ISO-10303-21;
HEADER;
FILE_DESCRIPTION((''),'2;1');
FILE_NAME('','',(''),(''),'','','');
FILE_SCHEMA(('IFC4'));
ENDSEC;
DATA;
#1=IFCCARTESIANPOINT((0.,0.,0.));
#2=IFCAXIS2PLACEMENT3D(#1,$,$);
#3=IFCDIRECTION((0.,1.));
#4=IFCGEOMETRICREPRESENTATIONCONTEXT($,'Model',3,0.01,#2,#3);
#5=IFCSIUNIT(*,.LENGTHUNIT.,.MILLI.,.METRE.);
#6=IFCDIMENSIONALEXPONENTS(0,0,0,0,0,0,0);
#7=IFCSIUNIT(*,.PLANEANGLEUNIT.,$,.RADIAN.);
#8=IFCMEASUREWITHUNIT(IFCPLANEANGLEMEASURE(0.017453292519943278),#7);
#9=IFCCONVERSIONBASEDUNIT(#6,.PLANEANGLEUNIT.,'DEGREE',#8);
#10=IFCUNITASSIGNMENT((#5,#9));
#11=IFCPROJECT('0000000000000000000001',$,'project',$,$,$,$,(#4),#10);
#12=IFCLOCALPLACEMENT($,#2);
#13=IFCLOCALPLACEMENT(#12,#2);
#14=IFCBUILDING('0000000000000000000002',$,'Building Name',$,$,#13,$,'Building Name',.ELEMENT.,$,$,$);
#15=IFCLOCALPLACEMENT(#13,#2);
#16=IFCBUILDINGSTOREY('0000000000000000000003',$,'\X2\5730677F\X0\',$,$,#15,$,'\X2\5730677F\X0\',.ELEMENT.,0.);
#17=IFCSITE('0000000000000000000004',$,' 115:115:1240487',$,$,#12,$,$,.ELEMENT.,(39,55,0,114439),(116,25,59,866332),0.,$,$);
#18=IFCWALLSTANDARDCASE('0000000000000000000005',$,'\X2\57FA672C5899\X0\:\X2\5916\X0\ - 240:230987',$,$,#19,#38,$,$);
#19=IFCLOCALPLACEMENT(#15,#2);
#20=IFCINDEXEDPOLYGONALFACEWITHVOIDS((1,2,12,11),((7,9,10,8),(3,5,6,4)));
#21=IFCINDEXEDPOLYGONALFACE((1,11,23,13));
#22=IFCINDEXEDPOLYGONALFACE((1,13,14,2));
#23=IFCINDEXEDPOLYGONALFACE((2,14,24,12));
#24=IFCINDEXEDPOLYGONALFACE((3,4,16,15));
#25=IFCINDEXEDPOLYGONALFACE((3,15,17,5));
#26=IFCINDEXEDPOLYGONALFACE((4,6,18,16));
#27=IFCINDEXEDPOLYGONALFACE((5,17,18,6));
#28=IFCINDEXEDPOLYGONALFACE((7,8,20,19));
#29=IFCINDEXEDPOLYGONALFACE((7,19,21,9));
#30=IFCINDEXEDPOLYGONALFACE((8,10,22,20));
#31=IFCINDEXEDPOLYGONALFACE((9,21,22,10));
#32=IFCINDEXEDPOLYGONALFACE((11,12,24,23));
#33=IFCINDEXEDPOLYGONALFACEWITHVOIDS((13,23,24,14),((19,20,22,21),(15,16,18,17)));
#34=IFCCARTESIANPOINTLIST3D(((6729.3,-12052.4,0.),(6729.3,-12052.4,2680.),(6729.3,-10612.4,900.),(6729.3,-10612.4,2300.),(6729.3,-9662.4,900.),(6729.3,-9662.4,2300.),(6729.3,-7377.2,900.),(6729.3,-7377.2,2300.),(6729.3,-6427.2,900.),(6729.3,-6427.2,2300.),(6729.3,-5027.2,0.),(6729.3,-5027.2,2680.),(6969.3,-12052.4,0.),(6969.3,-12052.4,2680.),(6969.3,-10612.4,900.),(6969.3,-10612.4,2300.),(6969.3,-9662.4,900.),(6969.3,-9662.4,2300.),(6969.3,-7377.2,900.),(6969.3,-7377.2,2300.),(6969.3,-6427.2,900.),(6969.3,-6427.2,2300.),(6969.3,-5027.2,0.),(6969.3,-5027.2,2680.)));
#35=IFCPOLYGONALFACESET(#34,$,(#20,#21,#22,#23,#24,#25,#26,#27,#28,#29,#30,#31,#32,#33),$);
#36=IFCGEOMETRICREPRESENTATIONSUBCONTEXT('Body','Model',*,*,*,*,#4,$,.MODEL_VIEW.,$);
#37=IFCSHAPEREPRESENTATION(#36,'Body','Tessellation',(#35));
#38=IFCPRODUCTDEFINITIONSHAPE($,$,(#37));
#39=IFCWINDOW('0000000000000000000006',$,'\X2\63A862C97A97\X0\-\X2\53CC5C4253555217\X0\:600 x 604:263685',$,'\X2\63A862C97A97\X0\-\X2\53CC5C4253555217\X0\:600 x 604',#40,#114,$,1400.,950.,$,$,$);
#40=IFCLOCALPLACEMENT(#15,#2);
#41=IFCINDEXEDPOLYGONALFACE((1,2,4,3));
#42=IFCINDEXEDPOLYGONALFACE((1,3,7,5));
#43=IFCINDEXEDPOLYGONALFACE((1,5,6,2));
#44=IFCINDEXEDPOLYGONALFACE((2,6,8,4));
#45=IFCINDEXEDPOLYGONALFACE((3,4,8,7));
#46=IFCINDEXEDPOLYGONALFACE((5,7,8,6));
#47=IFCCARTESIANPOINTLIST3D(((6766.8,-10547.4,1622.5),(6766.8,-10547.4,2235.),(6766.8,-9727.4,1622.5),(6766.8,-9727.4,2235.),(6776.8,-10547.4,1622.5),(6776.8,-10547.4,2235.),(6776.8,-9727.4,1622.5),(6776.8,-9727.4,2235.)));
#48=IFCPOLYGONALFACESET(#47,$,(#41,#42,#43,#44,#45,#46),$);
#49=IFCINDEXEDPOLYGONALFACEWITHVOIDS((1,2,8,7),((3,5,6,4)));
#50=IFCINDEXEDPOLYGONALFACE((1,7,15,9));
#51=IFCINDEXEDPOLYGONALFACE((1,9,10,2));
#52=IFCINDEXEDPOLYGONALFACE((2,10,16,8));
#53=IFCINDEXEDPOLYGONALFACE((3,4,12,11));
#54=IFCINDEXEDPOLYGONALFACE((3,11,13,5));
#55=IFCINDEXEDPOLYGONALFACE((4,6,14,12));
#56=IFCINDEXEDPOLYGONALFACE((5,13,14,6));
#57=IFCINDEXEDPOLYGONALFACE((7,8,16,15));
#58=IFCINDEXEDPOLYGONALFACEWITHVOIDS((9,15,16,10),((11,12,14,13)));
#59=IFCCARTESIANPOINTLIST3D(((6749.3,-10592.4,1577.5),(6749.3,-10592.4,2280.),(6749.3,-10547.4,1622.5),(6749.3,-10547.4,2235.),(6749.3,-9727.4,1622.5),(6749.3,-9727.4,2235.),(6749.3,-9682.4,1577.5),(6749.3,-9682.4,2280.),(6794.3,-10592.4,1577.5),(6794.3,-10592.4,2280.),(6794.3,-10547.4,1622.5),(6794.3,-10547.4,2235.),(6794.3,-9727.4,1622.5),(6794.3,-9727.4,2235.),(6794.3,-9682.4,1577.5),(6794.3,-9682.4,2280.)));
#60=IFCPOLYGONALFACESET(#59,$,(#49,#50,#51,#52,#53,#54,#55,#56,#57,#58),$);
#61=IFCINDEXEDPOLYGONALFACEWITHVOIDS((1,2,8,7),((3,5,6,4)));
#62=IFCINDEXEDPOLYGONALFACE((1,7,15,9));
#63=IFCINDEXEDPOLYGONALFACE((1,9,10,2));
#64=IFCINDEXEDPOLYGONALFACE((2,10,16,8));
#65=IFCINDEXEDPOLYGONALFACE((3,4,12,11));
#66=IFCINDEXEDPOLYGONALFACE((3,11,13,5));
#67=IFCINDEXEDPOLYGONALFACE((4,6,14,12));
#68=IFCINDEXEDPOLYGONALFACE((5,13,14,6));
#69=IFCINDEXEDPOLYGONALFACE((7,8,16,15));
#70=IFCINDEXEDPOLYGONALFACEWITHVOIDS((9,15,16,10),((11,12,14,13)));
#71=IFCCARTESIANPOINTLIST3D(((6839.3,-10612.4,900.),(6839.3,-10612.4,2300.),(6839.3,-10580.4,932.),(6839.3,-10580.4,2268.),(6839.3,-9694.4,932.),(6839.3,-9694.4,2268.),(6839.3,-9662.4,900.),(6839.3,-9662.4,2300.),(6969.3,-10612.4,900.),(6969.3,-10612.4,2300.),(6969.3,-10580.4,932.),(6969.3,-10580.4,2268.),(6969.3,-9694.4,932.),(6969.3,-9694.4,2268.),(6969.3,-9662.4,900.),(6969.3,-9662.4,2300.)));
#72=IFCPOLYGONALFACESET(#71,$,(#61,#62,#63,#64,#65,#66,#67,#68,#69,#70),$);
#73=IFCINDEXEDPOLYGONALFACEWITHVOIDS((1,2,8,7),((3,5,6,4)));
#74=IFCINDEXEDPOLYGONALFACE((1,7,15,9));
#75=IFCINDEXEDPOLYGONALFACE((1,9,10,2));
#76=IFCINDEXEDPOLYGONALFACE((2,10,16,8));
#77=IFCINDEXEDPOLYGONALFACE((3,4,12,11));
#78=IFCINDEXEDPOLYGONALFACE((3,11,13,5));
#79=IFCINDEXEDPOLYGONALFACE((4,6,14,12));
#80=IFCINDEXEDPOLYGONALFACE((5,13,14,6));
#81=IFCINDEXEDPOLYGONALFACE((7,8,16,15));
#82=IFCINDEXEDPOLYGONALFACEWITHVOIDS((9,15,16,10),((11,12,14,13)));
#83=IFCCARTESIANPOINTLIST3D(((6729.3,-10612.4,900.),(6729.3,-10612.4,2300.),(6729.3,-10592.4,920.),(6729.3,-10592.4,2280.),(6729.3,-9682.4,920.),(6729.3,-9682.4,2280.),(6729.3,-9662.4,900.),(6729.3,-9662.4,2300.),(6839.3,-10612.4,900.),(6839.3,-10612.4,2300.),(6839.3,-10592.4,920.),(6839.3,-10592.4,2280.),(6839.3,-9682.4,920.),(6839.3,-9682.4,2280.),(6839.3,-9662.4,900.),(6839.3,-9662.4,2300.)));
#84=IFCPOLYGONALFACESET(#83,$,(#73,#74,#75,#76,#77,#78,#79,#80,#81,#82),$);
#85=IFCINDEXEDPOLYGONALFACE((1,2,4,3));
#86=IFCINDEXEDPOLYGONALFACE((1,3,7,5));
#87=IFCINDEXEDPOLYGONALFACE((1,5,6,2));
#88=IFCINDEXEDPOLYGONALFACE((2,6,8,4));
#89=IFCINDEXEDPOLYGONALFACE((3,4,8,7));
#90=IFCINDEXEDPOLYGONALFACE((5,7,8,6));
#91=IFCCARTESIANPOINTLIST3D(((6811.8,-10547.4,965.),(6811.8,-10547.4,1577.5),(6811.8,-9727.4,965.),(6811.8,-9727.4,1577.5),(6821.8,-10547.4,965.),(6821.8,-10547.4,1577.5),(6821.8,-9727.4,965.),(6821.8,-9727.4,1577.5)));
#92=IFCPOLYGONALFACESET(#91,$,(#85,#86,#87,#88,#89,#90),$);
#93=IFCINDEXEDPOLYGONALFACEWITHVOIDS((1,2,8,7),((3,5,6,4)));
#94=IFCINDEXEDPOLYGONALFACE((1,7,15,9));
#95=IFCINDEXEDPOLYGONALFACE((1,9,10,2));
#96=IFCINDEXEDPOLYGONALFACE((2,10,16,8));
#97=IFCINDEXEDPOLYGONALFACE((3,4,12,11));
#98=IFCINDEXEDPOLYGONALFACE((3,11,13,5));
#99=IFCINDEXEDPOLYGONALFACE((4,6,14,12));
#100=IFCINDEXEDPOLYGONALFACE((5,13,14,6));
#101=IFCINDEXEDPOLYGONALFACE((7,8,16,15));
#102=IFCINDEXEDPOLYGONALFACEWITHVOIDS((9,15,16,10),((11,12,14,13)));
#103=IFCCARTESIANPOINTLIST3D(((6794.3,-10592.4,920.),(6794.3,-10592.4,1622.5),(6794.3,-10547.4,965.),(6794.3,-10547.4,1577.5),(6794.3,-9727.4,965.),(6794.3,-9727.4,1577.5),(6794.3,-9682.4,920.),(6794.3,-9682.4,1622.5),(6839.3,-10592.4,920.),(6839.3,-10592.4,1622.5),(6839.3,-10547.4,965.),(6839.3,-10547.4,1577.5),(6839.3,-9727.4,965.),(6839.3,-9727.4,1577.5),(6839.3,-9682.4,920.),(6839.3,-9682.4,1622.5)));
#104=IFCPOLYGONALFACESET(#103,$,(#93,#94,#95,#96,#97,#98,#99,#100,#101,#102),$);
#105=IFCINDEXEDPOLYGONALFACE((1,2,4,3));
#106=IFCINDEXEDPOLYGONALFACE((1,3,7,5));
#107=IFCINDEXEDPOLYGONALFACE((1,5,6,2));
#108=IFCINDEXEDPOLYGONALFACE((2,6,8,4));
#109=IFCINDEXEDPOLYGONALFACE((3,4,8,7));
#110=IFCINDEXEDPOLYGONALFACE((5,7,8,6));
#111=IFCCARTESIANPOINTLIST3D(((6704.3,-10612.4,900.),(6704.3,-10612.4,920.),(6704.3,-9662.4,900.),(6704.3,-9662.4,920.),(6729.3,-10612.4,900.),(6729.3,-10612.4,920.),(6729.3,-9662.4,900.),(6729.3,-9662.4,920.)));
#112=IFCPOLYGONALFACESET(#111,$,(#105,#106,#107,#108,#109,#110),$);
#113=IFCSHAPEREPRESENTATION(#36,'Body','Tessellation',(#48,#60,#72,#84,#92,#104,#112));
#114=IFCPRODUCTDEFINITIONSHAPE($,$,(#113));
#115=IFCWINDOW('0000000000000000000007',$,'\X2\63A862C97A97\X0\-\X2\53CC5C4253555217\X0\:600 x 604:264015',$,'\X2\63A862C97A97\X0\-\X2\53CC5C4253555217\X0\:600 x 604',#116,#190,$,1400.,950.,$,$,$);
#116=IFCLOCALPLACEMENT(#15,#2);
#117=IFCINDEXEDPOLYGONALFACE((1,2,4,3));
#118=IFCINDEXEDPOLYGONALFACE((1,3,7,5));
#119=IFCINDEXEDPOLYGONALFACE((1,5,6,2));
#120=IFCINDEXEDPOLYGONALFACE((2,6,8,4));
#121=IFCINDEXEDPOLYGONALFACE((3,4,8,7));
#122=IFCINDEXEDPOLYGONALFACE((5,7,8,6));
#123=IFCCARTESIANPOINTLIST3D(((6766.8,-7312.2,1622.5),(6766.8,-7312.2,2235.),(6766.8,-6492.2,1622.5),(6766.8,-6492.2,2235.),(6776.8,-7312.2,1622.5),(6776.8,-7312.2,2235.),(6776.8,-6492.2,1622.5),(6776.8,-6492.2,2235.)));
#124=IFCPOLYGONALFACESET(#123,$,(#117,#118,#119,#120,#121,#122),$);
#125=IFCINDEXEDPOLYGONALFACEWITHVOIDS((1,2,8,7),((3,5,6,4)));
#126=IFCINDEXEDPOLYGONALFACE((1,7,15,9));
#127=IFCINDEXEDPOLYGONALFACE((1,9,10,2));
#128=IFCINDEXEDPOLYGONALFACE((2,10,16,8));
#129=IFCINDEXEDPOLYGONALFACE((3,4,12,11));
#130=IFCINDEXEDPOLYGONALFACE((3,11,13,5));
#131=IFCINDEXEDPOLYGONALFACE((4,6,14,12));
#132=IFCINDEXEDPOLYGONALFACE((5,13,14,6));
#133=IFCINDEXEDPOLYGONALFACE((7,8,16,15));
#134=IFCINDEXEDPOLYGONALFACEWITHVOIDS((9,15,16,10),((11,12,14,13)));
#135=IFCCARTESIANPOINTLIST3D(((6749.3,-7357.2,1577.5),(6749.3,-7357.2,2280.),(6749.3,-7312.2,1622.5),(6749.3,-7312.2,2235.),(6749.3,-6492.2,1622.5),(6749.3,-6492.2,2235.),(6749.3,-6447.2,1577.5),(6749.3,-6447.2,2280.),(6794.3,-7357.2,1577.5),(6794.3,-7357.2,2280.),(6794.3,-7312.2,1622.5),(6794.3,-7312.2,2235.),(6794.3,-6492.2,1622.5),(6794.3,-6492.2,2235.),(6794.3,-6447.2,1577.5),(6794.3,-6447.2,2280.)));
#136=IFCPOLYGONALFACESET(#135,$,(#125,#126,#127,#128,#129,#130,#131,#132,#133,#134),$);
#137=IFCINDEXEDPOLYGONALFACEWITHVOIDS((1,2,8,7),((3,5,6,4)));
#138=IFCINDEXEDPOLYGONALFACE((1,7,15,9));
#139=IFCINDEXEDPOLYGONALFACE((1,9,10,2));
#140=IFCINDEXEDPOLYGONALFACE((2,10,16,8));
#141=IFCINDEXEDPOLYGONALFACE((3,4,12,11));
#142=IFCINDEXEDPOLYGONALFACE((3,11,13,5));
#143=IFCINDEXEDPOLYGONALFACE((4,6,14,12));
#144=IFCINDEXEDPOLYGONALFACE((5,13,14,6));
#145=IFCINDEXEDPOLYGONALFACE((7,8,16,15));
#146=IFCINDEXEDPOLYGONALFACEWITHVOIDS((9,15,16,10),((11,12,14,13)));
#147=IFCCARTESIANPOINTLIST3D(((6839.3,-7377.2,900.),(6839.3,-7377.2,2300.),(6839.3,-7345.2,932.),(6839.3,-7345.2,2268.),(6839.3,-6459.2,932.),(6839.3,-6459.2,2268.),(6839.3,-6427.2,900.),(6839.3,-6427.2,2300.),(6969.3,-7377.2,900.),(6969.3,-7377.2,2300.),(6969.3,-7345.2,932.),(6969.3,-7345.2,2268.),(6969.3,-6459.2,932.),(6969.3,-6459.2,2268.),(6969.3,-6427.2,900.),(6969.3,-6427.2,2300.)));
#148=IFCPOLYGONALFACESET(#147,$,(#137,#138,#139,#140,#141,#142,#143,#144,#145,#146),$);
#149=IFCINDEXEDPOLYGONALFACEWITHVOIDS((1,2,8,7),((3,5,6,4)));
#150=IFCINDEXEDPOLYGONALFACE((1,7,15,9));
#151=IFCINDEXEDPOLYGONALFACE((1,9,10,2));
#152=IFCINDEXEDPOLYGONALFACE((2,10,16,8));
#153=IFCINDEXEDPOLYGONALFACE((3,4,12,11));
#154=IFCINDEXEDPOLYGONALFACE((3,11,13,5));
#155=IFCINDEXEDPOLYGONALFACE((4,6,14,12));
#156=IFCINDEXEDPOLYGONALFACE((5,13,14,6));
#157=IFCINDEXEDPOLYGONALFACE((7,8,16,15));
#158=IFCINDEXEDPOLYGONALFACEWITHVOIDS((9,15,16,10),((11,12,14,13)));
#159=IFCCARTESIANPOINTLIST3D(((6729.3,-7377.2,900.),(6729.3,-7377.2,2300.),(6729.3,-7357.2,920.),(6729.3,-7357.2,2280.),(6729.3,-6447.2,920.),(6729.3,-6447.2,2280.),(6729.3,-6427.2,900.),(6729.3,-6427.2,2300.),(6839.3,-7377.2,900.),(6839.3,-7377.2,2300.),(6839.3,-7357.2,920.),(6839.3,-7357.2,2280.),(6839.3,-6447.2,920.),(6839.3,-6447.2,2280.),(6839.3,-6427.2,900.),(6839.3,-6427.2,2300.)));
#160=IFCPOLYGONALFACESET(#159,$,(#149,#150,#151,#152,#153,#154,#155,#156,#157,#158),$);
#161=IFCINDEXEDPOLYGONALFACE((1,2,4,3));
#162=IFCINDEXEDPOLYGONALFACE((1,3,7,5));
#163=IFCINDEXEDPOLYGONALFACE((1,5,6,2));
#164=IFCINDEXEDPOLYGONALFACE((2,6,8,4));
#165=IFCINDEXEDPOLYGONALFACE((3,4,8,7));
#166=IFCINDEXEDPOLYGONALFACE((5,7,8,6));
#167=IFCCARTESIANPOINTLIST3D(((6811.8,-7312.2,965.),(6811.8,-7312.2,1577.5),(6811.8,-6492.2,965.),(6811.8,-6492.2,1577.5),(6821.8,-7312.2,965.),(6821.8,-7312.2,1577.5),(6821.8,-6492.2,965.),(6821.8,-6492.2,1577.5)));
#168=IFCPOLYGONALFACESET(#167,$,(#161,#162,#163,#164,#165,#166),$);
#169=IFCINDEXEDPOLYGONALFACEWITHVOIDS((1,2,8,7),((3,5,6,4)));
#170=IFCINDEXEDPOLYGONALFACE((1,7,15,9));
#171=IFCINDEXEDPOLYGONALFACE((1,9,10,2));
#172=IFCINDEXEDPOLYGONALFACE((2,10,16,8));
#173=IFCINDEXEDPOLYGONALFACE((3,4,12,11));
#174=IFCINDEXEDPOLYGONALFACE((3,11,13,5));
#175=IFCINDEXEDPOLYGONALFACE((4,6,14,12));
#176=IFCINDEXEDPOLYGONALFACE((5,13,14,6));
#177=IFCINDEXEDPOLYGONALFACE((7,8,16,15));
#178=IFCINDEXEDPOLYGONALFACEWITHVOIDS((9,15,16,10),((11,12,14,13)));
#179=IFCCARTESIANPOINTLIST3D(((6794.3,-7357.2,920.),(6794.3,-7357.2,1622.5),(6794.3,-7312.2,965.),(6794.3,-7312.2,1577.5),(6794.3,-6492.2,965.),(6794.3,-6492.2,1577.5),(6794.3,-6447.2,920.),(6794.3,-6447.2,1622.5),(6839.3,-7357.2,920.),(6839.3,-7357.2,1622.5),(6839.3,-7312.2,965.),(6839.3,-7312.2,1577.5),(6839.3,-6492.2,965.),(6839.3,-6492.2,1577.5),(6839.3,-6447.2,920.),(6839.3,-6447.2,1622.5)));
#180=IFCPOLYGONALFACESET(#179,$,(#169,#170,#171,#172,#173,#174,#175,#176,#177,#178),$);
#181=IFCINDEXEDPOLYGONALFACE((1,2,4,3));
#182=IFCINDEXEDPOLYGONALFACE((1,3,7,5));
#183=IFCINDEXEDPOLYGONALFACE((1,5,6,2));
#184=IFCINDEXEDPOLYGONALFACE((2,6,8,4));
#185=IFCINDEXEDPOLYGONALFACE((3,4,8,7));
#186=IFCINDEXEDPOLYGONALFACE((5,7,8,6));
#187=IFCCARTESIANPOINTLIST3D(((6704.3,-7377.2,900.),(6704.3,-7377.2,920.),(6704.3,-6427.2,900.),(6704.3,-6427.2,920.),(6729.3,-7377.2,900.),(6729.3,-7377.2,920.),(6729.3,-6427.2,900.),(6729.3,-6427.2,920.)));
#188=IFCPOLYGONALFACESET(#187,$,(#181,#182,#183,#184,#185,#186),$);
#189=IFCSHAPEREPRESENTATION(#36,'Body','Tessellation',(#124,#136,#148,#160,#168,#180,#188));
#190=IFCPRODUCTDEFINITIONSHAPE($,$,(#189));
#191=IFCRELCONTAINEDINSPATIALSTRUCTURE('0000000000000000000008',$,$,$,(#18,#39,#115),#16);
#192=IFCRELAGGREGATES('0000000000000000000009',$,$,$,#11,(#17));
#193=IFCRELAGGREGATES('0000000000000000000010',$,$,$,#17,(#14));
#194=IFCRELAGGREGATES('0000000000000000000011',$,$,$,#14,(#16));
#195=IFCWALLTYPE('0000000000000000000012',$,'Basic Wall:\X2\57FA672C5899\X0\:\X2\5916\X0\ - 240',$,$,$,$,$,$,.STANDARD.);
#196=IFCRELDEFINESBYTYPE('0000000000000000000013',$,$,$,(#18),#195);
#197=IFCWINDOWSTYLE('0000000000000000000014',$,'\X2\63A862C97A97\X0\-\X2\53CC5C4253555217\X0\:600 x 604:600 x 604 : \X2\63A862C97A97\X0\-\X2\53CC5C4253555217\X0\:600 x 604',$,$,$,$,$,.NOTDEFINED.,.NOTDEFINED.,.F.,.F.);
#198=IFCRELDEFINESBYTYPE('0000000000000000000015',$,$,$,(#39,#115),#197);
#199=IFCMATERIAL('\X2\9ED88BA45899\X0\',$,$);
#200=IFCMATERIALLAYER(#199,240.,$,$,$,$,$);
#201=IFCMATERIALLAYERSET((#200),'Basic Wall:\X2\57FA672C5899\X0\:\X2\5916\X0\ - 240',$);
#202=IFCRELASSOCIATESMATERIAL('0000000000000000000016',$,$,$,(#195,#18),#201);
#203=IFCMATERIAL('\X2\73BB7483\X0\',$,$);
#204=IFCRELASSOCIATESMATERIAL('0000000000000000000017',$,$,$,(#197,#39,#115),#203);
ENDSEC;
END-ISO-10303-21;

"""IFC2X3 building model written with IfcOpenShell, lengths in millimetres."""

from ifc_helpers import new_model, entity, si_unit, converted_unit, direction, frame, frame_2d, origin, origin_2d_with_axis, place, context, subcontext, project, spatial, polyline, rectangle, outline, extrude, source, transform, mapped, material, layer, layer_set, layer_usage, type_object, type_shapes, element, fill, save


model = new_model("IFC2X3")

# Units and contexts
model_context = context("Model", 3, precision=0.01, world=origin(), true_north=direction((0.0, 1.0)))
body_context = subcontext(model_context, "Body", "Model", "MODEL_VIEW")
ifc_project = project(units=[si_unit("LENGTHUNIT", "METRE", prefix="MILLI"), converted_unit("PLANEANGLEUNIT", "DEGREE", entity("IfcPlaneAngleMeasure", 0.017453292519943278), si_unit("PLANEANGLEUNIT", "RADIAN"), dimensions=[0, 0, 0, 0, 0, 0, 0])], contexts=[model_context])

# Site, building, storey
site_placement = place(None, origin())
site = spatial("IfcSite", under=ifc_project, at=site_placement, Name=" 115:115:1240487", CompositionType="ELEMENT", RefLatitude=(39, 55, 0, 114439), RefLongitude=(116, 25, 59, 866332), RefElevation=0.0)
building_placement = place(site_placement, origin())
building = spatial("IfcBuilding", under=site, at=building_placement, Name="Building Name", LongName="Building Name", CompositionType="ELEMENT")
storey_placement = place(building_placement, origin())
storey = spatial("IfcBuildingStorey", under=building, at=storey_placement, Name="地板", LongName="地板", CompositionType="ELEMENT", Elevation=0.0)

# Shared definitions
ifc_material_1 = material(Name="默认墙")

# Shared definitions
ifc_layer_1 = layer(ifc_material_1, 240.0)
ifc_layer_set_1 = layer_set([ifc_layer_1], Name="Basic Wall:基本墙:外 - 240")
wall_type_1 = type_object("IfcWallType", Name="Basic Wall:基本墙:外 - 240", PredefinedType="STANDARD", material=ifc_layer_set_1)

# Wall, openings, windows
ifc_layer_usage_1 = layer_usage(ifc_layer_set_1, "AXIS2", "NEGATIVE", 120.0)
wall_1_placement = place(storey_placement, frame((6849.3, -12052.4, 0.0), z_axis=(0.0, 0.0, 1.0), x_axis=(0.0, 1.0, 0.0)))
wall_1 = element("IfcWallStandardCase", 1, at=wall_1_placement, inside=storey, type_object=wall_type_1, material=ifc_layer_usage_1, Name="基本墙:外 - 240:230987", context=body_context, shape_type="SweptSolid", body=[
    extrude(rectangle(XDim=7025.2, YDim=240.0, at=frame_2d((3512.6, 0.0), x_axis=(-1.0, 0.0))), origin(), (0.0, 0.0, 1.0), 2680.0),
])
opening_1_placement = place(wall_1_placement, frame((12052.4, 6849.3, 0.0), z_axis=(0.0, 0.0, 1.0), x_axis=(0.0, -1.0, 0.0)))
opening_1 = element("IfcOpeningElement", 2, at=opening_1_placement, cuts=wall_1, ObjectType="Opening", context=body_context, shape_type="SweptSolid", body=[
    extrude(rectangle(XDim=1400.0, YDim=950.0, at=frame_2d((0.0, 0.0), x_axis=(0.0, 1.0))), frame((6971.7, -10137.4, 1600.0), z_axis=(-1.0, 0.0, 0.0), x_axis=(0.0, -1.0, 0.0)), (0.0, 0.0, 1.0), 244.8),
])
opening_2_placement = place(wall_1_placement, frame((12052.4, 6849.3, 0.0), z_axis=(0.0, 0.0, 1.0), x_axis=(0.0, -1.0, 0.0)))
opening_2 = element("IfcOpeningElement", 3, at=opening_2_placement, cuts=wall_1, ObjectType="Opening", context=body_context, shape_type="SweptSolid", body=[
    extrude(rectangle(XDim=1400.0, YDim=950.0, at=frame_2d((0.0, 0.0), x_axis=(0.0, 1.0))), frame((6971.7, -6902.2, 1600.0), z_axis=(-1.0, 0.0, 0.0), x_axis=(0.0, -1.0, 0.0)), (0.0, 0.0, 1.0), 244.8),
])
ifc_material_2 = material(Name="玻璃")
window_style_1 = type_object("IfcWindowStyle", Name="推拉窗-双层单列:600 x 604:600 x 604 : 推拉窗-双层单列:600 x 604", ConstructionType="NOTDEFINED", OperationType="NOTDEFINED", ParameterTakesPrecedence=False, Sizeable=False, material=ifc_material_2)
shared_shape_1 = source(origin(), body_context, "Body", "SweptSolid", [
    extrude(rectangle(XDim=820.0, YDim=10.0, at=origin_2d_with_axis()), frame((475.0, -44.9, 722.5)), (0.0, 0.0, 1.0), 612.5),
    extrude(outline(polyline([(-351.2, -455.0), (351.2, -455.0), (351.2, 455.0), (-351.2, 455.0), (-351.2, -455.0)]), holes=[polyline([(306.2, 410.0), (306.2, -410.0), (-306.2, -410.0), (-306.2, 410.0), (306.2, 410.0)])]), frame((475.0, -67.4, 1028.7), z_axis=(0.0, 1.0, 0.0), x_axis=(0.0, 0.0, -1.0)), (0.0, 0.0, 1.0), 45.0),
    extrude(outline(polyline([(-700.0, -475.0), (700.0, -475.0), (700.0, 475.0), (-700.0, 475.0), (-700.0, -475.0)]), holes=[polyline([(668.0, 443.0), (668.0, -443.0), (-668.0, -443.0), (-668.0, 443.0), (668.0, 443.0)])]), frame((475.0, -242.4, 700.0), z_axis=(0.0, 1.0, 0.0), x_axis=(0.0, 0.0, -1.0)), (0.0, 0.0, 1.0), 130.0),
    extrude(outline(polyline([(-475.0, -700.0), (475.0, -700.0), (475.0, 700.0), (-475.0, 700.0), (-475.0, -700.0)]), holes=[polyline([(455.0, 680.0), (455.0, -680.0), (-455.0, -680.0), (-455.0, 680.0), (455.0, 680.0)])]), frame((475.0, -112.4, 700.0), z_axis=(0.0, 1.0, 0.0), x_axis=(-1.0, 0.0, 0.0)), (0.0, 0.0, 1.0), 110.0),
    extrude(rectangle(XDim=820.0, YDim=10.0, at=origin_2d_with_axis()), frame((475.0, -89.9, 65.0)), (0.0, 0.0, 1.0), 612.5),
    extrude(outline(polyline([(-351.2, -455.0), (351.2, -455.0), (351.2, 455.0), (-351.2, 455.0), (-351.2, -455.0)]), holes=[polyline([(306.2, 410.0), (306.3, -410.0), (-306.2, -410.0), (-306.2, 410.0), (306.2, 410.0)])]), frame((475.0, -112.4, 371.3), z_axis=(0.0, 1.0, 0.0), x_axis=(0.0, 0.0, -1.0)), (0.0, 0.0, 1.0), 45.0),
    extrude(rectangle(XDim=950.0, YDim=25.0, at=origin_2d_with_axis()), frame((475.0, 10.1, 0.0)), (0.0, 0.0, 1.0), 20.0),
])
type_shapes(window_style_1, [shared_shape_1])
window_1_placement = place(opening_1_placement, frame((6726.9, -10612.4, 900.0), z_axis=(0.0, 0.0, 1.0), x_axis=(0.0, 1.0, 0.0)))
window_1 = element("IfcWindow", 4, at=window_1_placement, inside=storey, type_object=window_style_1, material=ifc_material_2, Name="推拉窗-双层单列:600 x 604:263685", ObjectType="推拉窗-双层单列:600 x 604", OverallHeight=1400.0, OverallWidth=950.0, context=body_context, shape_type="MappedRepresentation", body=[
    mapped(shared_shape_1, transform((0.0, 0.0, 0.0), scale=1.0)),
])
fill(opening_1, window_1)
window_2_placement = place(opening_2_placement, frame((6726.9, -7377.2, 900.0), z_axis=(0.0, 0.0, 1.0), x_axis=(0.0, 1.0, 0.0)))
window_2 = element("IfcWindow", 5, at=window_2_placement, inside=storey, type_object=window_style_1, material=ifc_material_2, Name="推拉窗-双层单列:600 x 604:264015", ObjectType="推拉窗-双层单列:600 x 604", OverallHeight=1400.0, OverallWidth=950.0, context=body_context, shape_type="MappedRepresentation", body=[
    mapped(shared_shape_1, transform((0.0, 0.0, 0.0), scale=1.0)),
])
fill(opening_2, window_2)

save(model, "model.ifc")
